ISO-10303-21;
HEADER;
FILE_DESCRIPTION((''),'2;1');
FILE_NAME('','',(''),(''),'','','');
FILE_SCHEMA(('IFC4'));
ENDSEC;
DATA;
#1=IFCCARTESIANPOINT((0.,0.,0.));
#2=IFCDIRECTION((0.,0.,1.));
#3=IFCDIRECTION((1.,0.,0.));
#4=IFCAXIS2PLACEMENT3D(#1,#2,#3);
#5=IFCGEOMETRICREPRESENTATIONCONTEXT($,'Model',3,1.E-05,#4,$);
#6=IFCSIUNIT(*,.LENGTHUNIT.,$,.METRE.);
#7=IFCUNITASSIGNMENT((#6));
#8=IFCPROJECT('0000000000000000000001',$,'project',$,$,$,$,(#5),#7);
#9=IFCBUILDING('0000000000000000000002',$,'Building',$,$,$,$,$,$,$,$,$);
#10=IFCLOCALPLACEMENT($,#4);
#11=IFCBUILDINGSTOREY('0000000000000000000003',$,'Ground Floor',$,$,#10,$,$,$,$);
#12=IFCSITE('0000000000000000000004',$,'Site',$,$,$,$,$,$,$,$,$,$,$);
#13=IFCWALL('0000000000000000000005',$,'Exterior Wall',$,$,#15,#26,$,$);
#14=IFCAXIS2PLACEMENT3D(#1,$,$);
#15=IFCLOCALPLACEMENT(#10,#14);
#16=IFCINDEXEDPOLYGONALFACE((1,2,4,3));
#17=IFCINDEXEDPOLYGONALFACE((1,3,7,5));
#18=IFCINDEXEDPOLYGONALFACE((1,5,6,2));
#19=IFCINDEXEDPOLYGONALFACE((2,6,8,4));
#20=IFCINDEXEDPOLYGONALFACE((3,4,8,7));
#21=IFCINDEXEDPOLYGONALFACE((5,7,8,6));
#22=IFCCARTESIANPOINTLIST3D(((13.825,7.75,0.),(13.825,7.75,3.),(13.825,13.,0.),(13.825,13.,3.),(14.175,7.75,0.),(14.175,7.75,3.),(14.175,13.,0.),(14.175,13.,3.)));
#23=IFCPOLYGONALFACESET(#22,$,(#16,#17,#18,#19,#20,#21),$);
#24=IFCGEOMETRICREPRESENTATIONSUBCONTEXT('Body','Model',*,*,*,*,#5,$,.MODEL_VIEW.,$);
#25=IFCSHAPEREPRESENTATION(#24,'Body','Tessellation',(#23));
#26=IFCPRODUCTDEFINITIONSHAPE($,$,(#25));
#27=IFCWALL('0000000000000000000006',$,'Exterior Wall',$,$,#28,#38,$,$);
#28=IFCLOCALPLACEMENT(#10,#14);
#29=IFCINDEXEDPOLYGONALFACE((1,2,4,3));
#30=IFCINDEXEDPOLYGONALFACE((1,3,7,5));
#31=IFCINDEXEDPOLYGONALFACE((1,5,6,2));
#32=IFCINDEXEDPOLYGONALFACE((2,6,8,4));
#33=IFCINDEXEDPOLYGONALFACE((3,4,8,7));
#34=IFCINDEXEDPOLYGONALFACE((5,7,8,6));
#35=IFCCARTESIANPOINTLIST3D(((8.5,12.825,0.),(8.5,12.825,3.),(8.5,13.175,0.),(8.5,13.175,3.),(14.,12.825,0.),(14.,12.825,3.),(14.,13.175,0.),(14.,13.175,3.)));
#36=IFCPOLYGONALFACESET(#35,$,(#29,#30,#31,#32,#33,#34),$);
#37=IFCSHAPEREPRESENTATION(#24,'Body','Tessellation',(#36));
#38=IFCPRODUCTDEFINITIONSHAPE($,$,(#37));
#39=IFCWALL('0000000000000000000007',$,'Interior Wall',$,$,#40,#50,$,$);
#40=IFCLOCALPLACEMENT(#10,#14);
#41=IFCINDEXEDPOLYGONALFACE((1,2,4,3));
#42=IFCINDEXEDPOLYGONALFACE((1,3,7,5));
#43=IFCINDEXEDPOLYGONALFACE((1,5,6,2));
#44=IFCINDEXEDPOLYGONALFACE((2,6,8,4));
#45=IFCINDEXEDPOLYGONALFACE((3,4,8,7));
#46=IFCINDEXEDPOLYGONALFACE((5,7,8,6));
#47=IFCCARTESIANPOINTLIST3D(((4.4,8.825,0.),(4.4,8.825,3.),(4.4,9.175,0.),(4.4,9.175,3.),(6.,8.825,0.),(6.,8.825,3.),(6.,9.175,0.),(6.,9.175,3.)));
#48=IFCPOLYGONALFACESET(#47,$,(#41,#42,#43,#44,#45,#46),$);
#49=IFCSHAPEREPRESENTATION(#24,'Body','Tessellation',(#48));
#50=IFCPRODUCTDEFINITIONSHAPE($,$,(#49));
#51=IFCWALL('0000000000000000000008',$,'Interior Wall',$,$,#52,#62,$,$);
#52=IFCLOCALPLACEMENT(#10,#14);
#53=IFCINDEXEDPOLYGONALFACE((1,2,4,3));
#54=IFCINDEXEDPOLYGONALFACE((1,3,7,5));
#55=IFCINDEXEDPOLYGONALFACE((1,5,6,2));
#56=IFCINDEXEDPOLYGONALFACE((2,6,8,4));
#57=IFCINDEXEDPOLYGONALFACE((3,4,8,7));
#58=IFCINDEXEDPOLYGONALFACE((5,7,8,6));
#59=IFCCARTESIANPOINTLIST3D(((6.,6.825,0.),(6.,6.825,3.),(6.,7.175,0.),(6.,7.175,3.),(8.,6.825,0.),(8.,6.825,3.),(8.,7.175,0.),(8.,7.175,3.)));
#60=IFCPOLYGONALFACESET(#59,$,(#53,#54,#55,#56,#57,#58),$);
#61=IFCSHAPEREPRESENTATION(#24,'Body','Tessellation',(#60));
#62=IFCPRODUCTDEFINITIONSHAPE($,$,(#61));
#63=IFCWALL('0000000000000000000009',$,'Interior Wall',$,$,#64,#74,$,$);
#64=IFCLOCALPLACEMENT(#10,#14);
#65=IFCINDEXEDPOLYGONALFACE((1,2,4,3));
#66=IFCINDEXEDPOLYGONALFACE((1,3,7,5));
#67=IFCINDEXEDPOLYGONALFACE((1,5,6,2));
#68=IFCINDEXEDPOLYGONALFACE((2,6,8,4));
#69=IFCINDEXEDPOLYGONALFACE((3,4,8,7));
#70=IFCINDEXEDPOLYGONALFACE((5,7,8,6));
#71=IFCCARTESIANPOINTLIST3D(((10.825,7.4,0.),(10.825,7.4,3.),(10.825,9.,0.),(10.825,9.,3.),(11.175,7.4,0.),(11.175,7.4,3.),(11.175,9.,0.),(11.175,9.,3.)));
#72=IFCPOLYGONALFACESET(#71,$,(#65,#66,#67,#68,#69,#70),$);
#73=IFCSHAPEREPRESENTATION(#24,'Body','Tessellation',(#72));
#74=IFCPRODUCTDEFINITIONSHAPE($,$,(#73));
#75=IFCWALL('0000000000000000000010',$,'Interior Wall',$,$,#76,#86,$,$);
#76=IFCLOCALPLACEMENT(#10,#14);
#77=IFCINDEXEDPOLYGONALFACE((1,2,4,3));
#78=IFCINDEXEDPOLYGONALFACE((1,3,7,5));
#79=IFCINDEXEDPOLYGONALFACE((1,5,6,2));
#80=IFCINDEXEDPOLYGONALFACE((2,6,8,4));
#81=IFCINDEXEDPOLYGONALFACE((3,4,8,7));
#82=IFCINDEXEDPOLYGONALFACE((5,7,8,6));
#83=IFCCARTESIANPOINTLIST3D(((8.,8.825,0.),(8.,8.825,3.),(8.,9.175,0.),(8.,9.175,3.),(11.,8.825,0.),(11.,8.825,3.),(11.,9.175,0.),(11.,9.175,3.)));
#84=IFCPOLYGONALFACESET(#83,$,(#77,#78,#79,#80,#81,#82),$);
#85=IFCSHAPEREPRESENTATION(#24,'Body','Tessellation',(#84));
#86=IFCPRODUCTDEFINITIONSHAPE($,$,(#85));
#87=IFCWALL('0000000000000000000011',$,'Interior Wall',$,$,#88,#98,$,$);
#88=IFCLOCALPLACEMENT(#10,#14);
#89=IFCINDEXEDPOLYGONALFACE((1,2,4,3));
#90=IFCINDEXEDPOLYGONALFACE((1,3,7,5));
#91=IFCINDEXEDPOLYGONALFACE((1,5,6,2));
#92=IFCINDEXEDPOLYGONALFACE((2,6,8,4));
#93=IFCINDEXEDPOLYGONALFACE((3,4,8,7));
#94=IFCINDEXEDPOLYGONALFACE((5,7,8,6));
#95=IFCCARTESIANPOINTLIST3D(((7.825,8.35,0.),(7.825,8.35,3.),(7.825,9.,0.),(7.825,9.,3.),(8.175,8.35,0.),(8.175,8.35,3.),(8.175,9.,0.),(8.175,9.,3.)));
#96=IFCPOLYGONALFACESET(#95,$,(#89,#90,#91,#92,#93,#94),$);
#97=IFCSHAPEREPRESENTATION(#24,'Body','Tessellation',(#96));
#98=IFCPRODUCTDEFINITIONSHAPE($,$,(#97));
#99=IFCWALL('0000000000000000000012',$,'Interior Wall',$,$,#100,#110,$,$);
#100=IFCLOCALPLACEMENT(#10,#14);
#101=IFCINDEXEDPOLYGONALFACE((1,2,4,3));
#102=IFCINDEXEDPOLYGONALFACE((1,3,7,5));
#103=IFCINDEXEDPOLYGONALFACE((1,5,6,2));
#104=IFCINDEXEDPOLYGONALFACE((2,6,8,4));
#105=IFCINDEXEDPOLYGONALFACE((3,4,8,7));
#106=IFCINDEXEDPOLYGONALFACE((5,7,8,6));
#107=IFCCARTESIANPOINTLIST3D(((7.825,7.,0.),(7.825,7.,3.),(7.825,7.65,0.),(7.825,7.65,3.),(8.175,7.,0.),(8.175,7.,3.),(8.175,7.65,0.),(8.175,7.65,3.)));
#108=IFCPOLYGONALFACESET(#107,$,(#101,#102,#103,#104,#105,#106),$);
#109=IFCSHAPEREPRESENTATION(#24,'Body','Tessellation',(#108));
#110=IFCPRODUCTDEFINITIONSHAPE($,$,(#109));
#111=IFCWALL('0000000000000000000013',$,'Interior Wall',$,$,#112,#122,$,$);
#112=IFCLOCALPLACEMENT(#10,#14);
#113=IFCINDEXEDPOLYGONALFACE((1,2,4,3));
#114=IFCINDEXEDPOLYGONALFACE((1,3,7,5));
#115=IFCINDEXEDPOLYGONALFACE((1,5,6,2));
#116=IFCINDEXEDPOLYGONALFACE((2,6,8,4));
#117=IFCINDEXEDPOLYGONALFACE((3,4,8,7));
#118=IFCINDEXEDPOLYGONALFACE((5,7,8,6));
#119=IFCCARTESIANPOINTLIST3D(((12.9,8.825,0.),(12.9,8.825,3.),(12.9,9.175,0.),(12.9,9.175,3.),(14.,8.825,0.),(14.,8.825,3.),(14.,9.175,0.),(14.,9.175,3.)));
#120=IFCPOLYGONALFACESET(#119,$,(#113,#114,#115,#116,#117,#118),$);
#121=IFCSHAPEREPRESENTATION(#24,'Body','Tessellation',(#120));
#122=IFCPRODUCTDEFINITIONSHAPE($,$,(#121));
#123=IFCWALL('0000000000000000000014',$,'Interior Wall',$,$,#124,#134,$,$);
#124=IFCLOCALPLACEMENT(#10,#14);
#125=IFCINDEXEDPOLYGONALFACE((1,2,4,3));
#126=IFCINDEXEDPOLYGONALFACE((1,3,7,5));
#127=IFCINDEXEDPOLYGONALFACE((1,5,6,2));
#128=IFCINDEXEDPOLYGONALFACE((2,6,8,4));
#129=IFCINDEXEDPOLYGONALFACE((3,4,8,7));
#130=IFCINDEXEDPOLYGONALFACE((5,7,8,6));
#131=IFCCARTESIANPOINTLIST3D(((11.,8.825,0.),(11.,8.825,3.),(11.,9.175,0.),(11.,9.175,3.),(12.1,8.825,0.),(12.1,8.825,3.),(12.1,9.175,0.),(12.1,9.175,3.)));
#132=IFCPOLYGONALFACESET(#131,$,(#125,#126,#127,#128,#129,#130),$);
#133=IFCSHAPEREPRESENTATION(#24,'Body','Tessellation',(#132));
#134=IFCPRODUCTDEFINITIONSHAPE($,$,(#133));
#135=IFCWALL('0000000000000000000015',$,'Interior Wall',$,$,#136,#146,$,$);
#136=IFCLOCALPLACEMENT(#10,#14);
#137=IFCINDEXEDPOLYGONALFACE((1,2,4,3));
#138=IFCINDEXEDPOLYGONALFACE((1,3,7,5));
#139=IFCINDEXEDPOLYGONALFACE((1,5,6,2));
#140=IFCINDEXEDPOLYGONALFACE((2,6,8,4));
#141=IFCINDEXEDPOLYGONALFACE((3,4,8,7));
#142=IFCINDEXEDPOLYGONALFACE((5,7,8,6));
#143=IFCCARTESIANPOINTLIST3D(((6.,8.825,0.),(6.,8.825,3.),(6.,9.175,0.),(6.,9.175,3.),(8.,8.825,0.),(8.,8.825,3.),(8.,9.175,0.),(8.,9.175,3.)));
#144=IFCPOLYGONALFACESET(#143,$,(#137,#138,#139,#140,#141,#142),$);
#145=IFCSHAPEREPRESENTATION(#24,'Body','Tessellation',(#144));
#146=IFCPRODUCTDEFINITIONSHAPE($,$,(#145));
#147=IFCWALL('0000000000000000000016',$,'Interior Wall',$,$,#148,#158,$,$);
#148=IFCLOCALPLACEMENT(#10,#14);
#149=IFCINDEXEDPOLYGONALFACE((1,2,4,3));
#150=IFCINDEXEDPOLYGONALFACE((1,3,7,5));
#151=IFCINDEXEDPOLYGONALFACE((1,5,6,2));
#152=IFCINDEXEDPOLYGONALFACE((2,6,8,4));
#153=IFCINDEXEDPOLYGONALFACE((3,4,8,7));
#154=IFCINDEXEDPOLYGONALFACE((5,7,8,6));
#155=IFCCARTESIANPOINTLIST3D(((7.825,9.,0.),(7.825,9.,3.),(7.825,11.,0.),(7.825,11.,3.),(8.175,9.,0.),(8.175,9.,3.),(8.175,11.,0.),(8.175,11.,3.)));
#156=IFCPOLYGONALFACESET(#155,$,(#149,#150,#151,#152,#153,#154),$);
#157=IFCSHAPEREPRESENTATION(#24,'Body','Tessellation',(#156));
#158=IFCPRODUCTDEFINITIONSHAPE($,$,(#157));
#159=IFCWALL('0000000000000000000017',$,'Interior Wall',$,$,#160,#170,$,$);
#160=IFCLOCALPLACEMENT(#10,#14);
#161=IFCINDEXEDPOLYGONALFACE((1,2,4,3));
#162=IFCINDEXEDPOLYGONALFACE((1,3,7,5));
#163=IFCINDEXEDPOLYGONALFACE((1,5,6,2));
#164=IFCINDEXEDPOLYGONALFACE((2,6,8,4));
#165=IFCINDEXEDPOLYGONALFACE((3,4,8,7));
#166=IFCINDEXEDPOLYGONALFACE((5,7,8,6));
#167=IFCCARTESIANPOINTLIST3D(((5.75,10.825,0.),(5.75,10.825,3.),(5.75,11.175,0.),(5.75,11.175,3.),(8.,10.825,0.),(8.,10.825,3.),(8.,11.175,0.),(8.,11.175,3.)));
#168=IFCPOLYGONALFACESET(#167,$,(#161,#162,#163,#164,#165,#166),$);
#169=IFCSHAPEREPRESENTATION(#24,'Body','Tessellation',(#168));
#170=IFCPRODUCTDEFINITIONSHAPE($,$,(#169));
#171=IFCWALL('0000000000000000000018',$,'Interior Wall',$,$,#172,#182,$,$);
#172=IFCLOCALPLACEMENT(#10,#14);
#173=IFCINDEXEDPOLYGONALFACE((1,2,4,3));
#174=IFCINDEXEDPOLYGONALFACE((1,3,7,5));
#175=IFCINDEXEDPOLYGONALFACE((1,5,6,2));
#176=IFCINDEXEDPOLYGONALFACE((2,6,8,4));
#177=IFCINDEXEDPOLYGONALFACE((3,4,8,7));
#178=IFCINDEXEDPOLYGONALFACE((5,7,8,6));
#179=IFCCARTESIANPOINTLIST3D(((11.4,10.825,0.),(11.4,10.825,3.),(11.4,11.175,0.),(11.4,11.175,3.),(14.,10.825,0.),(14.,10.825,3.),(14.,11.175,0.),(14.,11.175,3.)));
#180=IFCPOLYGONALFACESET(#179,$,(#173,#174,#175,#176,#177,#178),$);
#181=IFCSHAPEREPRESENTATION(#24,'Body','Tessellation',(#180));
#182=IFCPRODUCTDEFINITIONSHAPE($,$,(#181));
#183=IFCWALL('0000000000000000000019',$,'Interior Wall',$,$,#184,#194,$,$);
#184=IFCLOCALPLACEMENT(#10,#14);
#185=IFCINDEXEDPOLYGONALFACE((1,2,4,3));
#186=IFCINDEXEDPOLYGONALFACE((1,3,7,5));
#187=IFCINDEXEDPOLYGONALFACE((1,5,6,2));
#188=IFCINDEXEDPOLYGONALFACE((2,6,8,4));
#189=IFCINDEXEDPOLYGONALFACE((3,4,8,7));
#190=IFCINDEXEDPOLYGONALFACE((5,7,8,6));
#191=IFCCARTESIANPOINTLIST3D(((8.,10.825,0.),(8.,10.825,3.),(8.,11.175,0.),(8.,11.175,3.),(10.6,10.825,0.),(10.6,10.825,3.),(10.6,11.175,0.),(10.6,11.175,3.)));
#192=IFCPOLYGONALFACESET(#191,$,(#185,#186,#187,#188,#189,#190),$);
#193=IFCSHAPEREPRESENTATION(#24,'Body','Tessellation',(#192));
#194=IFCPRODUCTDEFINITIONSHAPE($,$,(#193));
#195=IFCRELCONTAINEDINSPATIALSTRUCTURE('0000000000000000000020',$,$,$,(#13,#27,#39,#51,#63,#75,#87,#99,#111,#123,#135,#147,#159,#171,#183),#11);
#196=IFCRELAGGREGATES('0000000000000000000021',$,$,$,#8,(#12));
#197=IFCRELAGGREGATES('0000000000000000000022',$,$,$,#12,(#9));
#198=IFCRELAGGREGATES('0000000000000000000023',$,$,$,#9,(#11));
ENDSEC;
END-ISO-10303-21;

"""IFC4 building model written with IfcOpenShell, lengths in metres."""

from ifc_helpers import new_model, si_unit, frame, origin_with_axes, place, context, subcontext, project, spatial, indexed_curve, outline, extrude, element, save


model = new_model("IFC4")

# Units and contexts
model_context = context("Model", 3, precision=1e-05, world=origin_with_axes())
body_context = subcontext(model_context, "Body", "Model", "MODEL_VIEW")
ifc_project = project(units=[si_unit("LENGTHUNIT", "METRE")], contexts=[model_context])

# Site, building, storey
site = spatial("IfcSite", under=ifc_project, Name="Site")
building = spatial("IfcBuilding", under=site, Name="Building")
storey_placement = place(None, origin_with_axes())
storey = spatial("IfcBuildingStorey", under=building, at=storey_placement, Name="Ground Floor")

# Walls
wall_1_placement = place(storey_placement, frame((14.0, 7.75, 0.0), z_axis=(0.0, 0.0, 1.0), x_axis=(0.0, 1.0, 0.0)))
element("IfcWall", 1, at=wall_1_placement, inside=storey, Name="Exterior Wall", context=body_context, shape_type="SweptSolid", body=[
    extrude(outline(indexed_curve([(0.0, 0.0), (0.0, 0.35), (5.25, 0.35), (5.25, 0.0), (0.0, 0.0)], self_intersect=False)), frame((0.0, -0.175, 0.0), z_axis=(0.0, 0.0, 1.0), x_axis=(1.0, 0.0, 0.0)), (0.0, 0.0, 1.0), 3.0),
])
wall_2_placement = place(storey_placement, frame((14.0, 13.0, 0.0), z_axis=(0.0, 0.0, 1.0), x_axis=(-1.0, 0.0, 0.0)))
element("IfcWall", 2, at=wall_2_placement, inside=storey, Name="Exterior Wall", context=body_context, shape_type="SweptSolid", body=[
    extrude(outline(indexed_curve([(0.0, 0.0), (0.0, 0.35), (5.5, 0.35), (5.5, 0.0), (0.0, 0.0)], self_intersect=False)), frame((0.0, -0.175, 0.0), z_axis=(0.0, 0.0, 1.0), x_axis=(1.0, 0.0, 0.0)), (0.0, 0.0, 1.0), 3.0),
])
wall_3_placement = place(storey_placement, frame((6.0, 9.0, 0.0), z_axis=(0.0, 0.0, 1.0), x_axis=(-1.0, 0.0, 0.0)))
element("IfcWall", 3, at=wall_3_placement, inside=storey, Name="Interior Wall", context=body_context, shape_type="SweptSolid", body=[
    extrude(outline(indexed_curve([(0.0, 0.0), (0.0, 0.35), (1.6, 0.35), (1.6, 0.0), (0.0, 0.0)], self_intersect=False)), frame((0.0, -0.175, 0.0), z_axis=(0.0, 0.0, 1.0), x_axis=(1.0, 0.0, 0.0)), (0.0, 0.0, 1.0), 3.0),
])
wall_4_placement = place(storey_placement, frame((8.0, 7.0, 0.0), z_axis=(0.0, 0.0, 1.0), x_axis=(-1.0, 0.0, 0.0)))
element("IfcWall", 4, at=wall_4_placement, inside=storey, Name="Interior Wall", context=body_context, shape_type="SweptSolid", body=[
    extrude(outline(indexed_curve([(0.0, 0.0), (0.0, 0.35), (2.0, 0.35), (2.0, 0.0), (0.0, 0.0)], self_intersect=False)), frame((0.0, -0.175, 0.0), z_axis=(0.0, 0.0, 1.0), x_axis=(1.0, 0.0, 0.0)), (0.0, 0.0, 1.0), 3.0),
])
wall_5_placement = place(storey_placement, frame((11.0, 7.4, 0.0), z_axis=(0.0, 0.0, 1.0), x_axis=(0.0, 1.0, 0.0)))
element("IfcWall", 5, at=wall_5_placement, inside=storey, Name="Interior Wall", context=body_context, shape_type="SweptSolid", body=[
    extrude(outline(indexed_curve([(0.0, 0.0), (0.0, 0.35), (1.6, 0.35), (1.6, 0.0), (0.0, 0.0)], self_intersect=False)), frame((0.0, -0.175, 0.0), z_axis=(0.0, 0.0, 1.0), x_axis=(1.0, 0.0, 0.0)), (0.0, 0.0, 1.0), 3.0),
])
wall_6_placement = place(storey_placement, frame((11.0, 9.0, 0.0), z_axis=(0.0, 0.0, 1.0), x_axis=(-1.0, 0.0, 0.0)))
element("IfcWall", 6, at=wall_6_placement, inside=storey, Name="Interior Wall", context=body_context, shape_type="SweptSolid", body=[
    extrude(outline(indexed_curve([(0.0, 0.0), (0.0, 0.35), (3.0, 0.35), (3.0, 0.0), (0.0, 0.0)], self_intersect=False)), frame((0.0, -0.175, 0.0), z_axis=(0.0, 0.0, 1.0), x_axis=(1.0, 0.0, 0.0)), (0.0, 0.0, 1.0), 3.0),
])
for number, where, z_axis, x_axis, name in (
    (7, (8.0, 9.0, 0.0), (0.0, 0.0, 1.0), (0.0, -1.0, 0.0), "Interior Wall"),
    (8, (8.0, 7.65, 0.0), (0.0, 0.0, 1.0), (0.0, -1.0, 0.0), "Interior Wall"),
):
    element("IfcWall", number, at=place(storey_placement, frame(where, z_axis=z_axis, x_axis=x_axis)), inside=storey, Name=name, context=body_context, shape_type="SweptSolid", body=[
        extrude(outline(indexed_curve([(0.0, 0.0), (0.0, 0.35), (0.65, 0.35), (0.65, 0.0), (0.0, 0.0)], self_intersect=False)), frame((0.0, -0.175, 0.0), z_axis=(0.0, 0.0, 1.0), x_axis=(1.0, 0.0, 0.0)), (0.0, 0.0, 1.0), 3.0),
    ])
for number, where, z_axis, x_axis, name in (
    (9, (14.0, 9.0, 0.0), (0.0, 0.0, 1.0), (-1.0, 0.0, 0.0), "Interior Wall"),
    (10, (12.1, 9.0, 0.0), (0.0, 0.0, 1.0), (-1.0, 0.0, 0.0), "Interior Wall"),
):
    element("IfcWall", number, at=place(storey_placement, frame(where, z_axis=z_axis, x_axis=x_axis)), inside=storey, Name=name, context=body_context, shape_type="SweptSolid", body=[
        extrude(outline(indexed_curve([(0.0, 0.0), (0.0, 0.35), (1.1, 0.35), (1.1, 0.0), (0.0, 0.0)], self_intersect=False)), frame((0.0, -0.175, 0.0), z_axis=(0.0, 0.0, 1.0), x_axis=(1.0, 0.0, 0.0)), (0.0, 0.0, 1.0), 3.0),
    ])
for number, where, z_axis, x_axis, name in (
    (11, (8.0, 9.0, 0.0), (0.0, 0.0, 1.0), (-1.0, 0.0, 0.0), "Interior Wall"),
    (12, (8.0, 9.0, 0.0), (0.0, 0.0, 1.0), (0.0, 1.0, 0.0), "Interior Wall"),
):
    element("IfcWall", number, at=place(storey_placement, frame(where, z_axis=z_axis, x_axis=x_axis)), inside=storey, Name=name, context=body_context, shape_type="SweptSolid", body=[
        extrude(outline(indexed_curve([(0.0, 0.0), (0.0, 0.35), (2.0, 0.35), (2.0, 0.0), (0.0, 0.0)], self_intersect=False)), frame((0.0, -0.175, 0.0), z_axis=(0.0, 0.0, 1.0), x_axis=(1.0, 0.0, 0.0)), (0.0, 0.0, 1.0), 3.0),
    ])
wall_7_placement = place(storey_placement, frame((8.0, 11.0, 0.0), z_axis=(0.0, 0.0, 1.0), x_axis=(-1.0, 0.0, 0.0)))
element("IfcWall", 13, at=wall_7_placement, inside=storey, Name="Interior Wall", context=body_context, shape_type="SweptSolid", body=[
    extrude(outline(indexed_curve([(0.0, 0.0), (0.0, 0.35), (2.25, 0.35), (2.25, 0.0), (0.0, 0.0)], self_intersect=False)), frame((0.0, -0.175, 0.0), z_axis=(0.0, 0.0, 1.0), x_axis=(1.0, 0.0, 0.0)), (0.0, 0.0, 1.0), 3.0),
])
for number, where, z_axis, x_axis, name in (
    (14, (14.0, 11.0, 0.0), (0.0, 0.0, 1.0), (-1.0, 0.0, 0.0), "Interior Wall"),
    (15, (10.6, 11.0, 0.0), (0.0, 0.0, 1.0), (-1.0, 0.0, 0.0), "Interior Wall"),
):
    element("IfcWall", number, at=place(storey_placement, frame(where, z_axis=z_axis, x_axis=x_axis)), inside=storey, Name=name, context=body_context, shape_type="SweptSolid", body=[
        extrude(outline(indexed_curve([(0.0, 0.0), (0.0, 0.35), (2.6, 0.35), (2.6, 0.0), (0.0, 0.0)], self_intersect=False)), frame((0.0, -0.175, 0.0), z_axis=(0.0, 0.0, 1.0), x_axis=(1.0, 0.0, 0.0)), (0.0, 0.0, 1.0), 3.0),
    ])

save(model, "model.ifc")
